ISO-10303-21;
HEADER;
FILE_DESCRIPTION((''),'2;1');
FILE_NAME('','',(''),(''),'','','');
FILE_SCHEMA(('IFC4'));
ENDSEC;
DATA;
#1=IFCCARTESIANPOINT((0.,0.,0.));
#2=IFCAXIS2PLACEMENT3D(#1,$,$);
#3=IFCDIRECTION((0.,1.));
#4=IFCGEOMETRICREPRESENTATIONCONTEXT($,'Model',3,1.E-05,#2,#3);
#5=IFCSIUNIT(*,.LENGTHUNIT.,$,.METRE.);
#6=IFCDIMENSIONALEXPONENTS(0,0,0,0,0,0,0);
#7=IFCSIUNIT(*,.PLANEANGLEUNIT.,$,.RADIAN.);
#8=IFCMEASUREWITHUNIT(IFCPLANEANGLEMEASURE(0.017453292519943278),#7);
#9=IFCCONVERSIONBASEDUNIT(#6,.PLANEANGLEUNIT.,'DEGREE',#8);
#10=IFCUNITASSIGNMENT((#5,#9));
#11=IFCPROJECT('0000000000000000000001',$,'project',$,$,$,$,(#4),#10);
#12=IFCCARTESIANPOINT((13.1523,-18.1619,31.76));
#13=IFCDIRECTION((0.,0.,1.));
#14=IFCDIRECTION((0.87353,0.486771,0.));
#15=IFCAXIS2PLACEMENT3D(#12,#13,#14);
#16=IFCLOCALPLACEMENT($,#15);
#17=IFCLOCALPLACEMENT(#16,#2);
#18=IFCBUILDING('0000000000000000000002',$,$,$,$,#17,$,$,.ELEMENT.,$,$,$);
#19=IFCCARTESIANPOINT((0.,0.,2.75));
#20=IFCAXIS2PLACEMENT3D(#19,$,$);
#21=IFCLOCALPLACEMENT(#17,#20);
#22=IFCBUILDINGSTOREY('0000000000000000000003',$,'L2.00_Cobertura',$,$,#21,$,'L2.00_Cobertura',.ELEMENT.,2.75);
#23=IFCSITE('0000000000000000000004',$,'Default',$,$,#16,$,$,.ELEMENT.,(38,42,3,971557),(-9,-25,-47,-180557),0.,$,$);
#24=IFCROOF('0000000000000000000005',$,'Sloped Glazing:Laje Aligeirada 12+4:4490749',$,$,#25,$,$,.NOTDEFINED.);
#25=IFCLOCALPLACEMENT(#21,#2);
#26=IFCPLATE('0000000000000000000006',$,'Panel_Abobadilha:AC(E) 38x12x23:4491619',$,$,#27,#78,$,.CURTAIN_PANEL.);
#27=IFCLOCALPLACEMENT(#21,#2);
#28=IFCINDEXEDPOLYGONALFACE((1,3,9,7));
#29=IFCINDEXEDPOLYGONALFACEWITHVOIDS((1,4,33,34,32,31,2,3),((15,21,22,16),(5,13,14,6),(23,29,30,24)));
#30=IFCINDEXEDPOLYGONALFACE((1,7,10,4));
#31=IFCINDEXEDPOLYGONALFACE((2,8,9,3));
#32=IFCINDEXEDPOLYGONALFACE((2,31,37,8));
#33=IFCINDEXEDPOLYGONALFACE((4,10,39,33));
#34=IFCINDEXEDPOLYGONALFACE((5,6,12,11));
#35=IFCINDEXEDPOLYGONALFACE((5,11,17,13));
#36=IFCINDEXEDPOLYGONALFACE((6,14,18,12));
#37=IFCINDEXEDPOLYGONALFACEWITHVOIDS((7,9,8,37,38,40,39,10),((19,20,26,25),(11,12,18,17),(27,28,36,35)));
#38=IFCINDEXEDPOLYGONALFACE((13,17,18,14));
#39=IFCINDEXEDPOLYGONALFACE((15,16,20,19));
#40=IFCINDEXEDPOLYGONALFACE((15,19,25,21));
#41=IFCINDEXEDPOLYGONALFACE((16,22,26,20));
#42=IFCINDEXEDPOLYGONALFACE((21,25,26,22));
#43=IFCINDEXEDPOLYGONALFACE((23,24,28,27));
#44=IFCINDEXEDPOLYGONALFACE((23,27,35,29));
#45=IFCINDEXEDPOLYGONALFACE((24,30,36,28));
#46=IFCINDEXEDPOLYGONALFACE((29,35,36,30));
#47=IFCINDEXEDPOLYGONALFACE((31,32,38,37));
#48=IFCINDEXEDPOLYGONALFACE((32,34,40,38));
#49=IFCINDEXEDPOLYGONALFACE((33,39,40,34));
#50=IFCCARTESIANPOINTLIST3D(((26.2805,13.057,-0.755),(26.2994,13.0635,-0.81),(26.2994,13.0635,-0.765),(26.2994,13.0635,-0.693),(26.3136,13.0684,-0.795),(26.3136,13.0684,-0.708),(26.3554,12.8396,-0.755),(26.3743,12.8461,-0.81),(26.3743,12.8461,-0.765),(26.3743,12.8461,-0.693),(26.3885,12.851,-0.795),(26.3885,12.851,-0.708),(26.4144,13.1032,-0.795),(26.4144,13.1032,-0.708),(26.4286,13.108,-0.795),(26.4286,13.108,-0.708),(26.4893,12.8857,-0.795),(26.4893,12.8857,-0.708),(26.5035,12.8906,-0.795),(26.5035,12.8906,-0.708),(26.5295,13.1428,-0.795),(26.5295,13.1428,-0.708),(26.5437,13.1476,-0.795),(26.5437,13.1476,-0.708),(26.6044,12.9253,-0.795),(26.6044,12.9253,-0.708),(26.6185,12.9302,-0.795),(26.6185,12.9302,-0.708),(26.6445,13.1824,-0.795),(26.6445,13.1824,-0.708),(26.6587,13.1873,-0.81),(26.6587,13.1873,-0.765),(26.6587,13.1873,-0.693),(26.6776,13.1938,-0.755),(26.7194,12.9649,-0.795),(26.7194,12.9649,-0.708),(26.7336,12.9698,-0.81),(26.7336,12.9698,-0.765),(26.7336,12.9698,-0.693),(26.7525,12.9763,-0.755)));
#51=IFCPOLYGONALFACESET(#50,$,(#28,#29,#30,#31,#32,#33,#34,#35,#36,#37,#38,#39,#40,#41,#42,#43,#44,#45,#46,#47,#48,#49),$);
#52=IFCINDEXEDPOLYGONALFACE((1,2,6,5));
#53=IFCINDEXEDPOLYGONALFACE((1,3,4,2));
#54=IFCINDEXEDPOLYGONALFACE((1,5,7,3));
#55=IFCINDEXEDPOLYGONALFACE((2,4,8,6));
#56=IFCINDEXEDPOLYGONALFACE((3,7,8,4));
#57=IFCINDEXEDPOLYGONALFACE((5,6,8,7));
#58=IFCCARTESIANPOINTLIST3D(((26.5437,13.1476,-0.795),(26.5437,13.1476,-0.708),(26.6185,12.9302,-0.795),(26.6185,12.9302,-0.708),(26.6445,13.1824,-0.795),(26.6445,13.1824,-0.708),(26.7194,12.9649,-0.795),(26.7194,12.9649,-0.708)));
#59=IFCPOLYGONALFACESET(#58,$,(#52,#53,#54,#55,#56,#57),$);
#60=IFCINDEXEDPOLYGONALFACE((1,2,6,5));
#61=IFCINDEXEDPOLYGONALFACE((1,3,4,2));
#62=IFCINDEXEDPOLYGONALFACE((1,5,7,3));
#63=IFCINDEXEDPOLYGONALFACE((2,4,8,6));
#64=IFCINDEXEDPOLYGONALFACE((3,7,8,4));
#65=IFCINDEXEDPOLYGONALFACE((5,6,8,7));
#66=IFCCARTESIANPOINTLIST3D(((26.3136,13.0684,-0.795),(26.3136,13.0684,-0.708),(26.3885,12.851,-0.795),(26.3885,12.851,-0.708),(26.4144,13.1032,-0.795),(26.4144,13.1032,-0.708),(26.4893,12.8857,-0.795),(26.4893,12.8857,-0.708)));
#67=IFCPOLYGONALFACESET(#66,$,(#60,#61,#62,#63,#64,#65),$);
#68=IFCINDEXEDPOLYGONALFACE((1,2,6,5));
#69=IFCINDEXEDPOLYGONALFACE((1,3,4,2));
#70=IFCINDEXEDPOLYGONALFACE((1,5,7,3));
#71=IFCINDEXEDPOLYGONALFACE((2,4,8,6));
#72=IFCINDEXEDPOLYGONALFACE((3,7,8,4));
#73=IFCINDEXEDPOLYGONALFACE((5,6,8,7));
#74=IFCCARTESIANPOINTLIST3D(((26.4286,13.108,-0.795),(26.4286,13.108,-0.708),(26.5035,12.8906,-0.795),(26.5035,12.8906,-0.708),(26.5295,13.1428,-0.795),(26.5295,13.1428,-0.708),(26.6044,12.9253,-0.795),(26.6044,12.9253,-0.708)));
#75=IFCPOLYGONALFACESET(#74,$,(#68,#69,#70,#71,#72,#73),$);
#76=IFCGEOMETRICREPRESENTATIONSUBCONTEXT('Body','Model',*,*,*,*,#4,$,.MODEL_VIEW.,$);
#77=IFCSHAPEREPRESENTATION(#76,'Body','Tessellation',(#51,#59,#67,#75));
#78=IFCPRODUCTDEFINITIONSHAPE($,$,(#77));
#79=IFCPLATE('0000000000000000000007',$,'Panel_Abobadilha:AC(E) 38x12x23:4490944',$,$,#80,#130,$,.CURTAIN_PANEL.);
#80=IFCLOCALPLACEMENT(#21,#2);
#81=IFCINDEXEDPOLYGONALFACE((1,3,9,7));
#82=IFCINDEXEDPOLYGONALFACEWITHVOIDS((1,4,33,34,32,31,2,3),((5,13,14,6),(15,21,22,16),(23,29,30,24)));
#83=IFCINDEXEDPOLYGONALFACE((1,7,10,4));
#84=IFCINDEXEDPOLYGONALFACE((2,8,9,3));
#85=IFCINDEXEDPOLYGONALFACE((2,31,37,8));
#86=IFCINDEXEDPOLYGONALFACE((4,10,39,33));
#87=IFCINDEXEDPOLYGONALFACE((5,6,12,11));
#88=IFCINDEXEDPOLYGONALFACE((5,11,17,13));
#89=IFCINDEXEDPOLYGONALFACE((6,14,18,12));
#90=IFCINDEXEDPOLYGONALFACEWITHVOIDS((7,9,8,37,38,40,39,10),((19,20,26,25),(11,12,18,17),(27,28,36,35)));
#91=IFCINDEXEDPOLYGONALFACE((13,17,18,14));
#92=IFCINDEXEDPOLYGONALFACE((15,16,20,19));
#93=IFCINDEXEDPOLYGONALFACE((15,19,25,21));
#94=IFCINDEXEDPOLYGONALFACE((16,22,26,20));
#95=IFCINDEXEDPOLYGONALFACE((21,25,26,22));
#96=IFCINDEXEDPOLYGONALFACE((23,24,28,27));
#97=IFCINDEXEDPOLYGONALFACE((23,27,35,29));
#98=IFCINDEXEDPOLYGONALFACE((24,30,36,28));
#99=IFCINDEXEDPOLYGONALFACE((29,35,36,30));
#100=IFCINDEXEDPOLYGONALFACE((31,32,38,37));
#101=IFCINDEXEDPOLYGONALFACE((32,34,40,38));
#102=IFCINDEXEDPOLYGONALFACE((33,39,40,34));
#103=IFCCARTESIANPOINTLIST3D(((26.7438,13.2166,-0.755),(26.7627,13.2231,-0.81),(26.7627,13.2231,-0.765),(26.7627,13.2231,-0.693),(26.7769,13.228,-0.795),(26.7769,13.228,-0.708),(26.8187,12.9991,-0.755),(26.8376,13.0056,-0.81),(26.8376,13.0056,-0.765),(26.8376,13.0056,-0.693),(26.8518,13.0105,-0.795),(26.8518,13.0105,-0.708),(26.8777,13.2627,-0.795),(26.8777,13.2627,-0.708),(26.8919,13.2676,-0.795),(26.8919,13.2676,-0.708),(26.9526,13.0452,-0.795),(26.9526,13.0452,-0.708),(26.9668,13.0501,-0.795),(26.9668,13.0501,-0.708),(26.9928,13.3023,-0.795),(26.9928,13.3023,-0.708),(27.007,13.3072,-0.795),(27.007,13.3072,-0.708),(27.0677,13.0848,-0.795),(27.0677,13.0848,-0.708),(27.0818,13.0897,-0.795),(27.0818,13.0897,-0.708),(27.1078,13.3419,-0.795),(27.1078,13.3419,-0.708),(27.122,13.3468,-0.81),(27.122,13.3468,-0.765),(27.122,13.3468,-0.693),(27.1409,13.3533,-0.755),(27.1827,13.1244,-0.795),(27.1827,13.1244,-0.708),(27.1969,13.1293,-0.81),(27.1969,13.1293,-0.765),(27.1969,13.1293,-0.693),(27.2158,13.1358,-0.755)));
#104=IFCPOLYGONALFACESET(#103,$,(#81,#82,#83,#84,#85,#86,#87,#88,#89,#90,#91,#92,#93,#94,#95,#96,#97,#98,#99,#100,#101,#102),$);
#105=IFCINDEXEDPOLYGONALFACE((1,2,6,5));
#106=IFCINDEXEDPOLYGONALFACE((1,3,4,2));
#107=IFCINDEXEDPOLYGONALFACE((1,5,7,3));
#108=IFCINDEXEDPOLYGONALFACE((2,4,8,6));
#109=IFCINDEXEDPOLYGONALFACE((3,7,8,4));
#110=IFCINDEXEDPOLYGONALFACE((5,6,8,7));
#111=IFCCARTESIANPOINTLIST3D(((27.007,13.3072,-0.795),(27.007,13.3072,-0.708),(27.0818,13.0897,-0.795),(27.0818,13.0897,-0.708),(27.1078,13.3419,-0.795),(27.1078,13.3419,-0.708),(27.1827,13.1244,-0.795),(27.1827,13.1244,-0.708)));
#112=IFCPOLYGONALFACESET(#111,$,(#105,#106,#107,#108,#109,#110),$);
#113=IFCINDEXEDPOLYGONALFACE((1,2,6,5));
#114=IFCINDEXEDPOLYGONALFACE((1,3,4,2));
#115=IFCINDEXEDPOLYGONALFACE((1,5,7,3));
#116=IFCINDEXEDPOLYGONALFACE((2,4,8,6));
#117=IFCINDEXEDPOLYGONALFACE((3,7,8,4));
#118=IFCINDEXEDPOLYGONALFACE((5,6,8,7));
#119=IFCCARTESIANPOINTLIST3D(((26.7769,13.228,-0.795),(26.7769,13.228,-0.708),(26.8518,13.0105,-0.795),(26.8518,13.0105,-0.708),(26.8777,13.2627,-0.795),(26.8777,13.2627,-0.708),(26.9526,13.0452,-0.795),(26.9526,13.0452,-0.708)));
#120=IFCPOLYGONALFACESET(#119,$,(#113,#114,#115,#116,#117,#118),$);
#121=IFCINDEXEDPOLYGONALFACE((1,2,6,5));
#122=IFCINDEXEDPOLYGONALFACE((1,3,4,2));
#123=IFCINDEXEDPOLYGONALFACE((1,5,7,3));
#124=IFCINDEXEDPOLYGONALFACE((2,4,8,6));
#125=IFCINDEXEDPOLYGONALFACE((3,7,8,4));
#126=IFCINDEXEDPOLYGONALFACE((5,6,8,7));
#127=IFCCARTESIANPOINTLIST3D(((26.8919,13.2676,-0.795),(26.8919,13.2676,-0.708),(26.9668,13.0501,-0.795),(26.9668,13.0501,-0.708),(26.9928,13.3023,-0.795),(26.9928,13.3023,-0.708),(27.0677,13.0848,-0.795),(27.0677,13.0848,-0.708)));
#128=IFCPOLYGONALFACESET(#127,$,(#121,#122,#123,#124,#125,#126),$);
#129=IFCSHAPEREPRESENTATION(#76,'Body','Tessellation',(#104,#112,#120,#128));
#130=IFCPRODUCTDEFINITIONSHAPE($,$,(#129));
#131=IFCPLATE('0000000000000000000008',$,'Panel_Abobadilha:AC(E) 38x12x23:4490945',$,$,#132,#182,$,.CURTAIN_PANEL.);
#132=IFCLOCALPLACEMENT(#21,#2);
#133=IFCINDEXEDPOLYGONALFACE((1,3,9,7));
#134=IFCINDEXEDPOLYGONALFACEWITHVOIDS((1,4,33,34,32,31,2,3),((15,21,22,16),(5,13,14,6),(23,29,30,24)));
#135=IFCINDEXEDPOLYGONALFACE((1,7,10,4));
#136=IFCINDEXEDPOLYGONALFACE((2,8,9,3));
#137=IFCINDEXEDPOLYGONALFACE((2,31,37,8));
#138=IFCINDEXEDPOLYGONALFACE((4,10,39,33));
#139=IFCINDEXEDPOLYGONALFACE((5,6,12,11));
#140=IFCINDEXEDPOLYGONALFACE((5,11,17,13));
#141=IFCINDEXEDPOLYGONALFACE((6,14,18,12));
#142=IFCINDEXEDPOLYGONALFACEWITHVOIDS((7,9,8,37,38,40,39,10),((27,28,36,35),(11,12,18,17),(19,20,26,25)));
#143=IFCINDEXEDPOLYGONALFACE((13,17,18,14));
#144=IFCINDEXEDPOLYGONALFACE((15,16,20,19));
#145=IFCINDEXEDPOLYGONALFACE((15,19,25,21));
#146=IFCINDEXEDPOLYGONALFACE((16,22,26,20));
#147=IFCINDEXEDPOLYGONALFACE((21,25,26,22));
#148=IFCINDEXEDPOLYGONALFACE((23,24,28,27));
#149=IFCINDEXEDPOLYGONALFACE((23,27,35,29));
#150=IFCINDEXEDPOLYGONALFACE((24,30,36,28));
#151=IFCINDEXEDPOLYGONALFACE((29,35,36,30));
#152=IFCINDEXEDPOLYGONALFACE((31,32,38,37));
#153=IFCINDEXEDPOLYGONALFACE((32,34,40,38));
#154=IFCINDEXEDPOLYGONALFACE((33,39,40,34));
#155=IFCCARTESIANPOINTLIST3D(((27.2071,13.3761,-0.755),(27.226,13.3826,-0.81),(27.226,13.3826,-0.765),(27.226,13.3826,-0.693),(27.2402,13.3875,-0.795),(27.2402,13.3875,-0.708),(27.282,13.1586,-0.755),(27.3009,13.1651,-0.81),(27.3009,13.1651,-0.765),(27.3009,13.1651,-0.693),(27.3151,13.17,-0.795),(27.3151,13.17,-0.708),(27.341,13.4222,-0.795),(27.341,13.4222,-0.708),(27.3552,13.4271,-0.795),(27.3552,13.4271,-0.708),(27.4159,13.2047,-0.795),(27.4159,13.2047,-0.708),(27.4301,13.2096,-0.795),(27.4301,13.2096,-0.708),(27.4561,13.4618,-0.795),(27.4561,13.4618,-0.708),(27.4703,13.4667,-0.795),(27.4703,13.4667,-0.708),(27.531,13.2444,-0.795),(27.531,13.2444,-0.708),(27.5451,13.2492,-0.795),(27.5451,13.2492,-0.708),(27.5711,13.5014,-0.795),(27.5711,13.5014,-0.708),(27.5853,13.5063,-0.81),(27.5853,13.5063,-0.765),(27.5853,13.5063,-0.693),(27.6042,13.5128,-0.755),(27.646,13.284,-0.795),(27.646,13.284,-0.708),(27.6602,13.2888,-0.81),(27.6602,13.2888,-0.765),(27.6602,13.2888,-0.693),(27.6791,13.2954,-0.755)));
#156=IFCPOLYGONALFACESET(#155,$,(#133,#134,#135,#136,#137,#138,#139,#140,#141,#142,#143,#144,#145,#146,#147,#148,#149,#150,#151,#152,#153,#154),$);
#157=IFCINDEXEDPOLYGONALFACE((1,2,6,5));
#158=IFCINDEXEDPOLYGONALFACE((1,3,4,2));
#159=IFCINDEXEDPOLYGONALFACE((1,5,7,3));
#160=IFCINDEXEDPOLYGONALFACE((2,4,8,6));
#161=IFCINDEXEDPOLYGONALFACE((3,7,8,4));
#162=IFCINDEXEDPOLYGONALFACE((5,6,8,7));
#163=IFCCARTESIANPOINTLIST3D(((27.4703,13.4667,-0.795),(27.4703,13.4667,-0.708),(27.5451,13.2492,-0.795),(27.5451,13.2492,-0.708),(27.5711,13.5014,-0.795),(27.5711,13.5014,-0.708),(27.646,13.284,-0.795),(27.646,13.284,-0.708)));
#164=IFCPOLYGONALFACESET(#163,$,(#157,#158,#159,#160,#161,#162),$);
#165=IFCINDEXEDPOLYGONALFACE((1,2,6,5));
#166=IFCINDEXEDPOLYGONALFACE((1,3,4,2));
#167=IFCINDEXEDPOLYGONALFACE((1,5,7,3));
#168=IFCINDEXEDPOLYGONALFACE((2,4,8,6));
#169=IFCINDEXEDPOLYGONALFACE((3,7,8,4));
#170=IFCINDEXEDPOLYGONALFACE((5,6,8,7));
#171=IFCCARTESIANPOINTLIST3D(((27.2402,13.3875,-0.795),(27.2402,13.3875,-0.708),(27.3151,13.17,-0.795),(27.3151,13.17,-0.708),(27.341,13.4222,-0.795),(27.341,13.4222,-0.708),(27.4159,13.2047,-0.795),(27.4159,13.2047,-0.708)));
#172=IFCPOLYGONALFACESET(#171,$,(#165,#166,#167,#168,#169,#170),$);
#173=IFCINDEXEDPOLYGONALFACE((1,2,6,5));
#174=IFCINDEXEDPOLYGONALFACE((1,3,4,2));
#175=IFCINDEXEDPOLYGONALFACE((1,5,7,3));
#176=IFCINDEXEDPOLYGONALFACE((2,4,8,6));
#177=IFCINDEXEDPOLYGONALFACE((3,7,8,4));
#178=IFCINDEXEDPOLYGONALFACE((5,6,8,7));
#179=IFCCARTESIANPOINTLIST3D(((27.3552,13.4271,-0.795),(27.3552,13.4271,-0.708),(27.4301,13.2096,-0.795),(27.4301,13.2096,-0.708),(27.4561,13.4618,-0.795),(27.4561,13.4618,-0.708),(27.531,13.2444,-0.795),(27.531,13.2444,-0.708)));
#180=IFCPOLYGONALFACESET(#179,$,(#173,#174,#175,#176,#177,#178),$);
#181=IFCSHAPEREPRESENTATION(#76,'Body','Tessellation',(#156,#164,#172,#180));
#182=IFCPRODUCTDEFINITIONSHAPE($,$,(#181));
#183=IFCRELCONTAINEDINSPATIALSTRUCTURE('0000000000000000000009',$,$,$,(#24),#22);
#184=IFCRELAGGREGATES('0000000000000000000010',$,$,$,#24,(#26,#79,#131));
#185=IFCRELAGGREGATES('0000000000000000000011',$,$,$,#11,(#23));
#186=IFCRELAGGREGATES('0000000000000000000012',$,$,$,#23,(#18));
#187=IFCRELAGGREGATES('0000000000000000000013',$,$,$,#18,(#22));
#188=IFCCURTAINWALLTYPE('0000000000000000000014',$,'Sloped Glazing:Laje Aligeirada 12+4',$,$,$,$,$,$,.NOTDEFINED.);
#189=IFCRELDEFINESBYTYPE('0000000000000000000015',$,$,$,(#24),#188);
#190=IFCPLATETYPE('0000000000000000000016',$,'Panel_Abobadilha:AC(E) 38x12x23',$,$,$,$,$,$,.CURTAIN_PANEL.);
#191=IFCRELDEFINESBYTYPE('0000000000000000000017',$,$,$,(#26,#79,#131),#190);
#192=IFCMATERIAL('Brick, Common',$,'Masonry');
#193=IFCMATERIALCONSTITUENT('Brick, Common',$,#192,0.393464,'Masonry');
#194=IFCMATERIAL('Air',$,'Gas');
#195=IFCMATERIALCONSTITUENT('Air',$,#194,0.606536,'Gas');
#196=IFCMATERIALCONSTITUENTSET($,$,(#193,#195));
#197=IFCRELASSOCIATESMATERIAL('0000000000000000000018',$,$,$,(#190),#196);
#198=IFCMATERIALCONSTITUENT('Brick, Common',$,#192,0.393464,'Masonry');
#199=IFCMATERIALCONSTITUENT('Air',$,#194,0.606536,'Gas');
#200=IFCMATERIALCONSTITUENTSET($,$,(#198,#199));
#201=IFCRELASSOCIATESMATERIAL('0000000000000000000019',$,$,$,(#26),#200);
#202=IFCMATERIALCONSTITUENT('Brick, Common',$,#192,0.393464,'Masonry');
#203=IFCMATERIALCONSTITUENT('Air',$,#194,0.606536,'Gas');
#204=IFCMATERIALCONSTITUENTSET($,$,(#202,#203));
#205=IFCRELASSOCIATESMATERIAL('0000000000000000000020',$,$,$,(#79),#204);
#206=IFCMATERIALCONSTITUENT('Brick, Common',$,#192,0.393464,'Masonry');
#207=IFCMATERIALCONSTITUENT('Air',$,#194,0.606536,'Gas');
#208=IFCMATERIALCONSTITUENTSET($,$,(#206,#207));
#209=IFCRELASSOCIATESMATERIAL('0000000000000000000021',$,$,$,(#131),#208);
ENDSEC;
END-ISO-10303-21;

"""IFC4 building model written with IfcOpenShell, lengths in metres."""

from ifc_helpers import new_model, entity, si_unit, converted_unit, direction, frame, origin, place, context, subcontext, project, spatial, indexed_curve, outline, extrude, source, transform, mapped, material, constituent, constituent_set, type_object, type_shapes, element, aggregate, save


model = new_model("IFC4")

# Units and contexts
model_context = context("Model", 3, precision=1e-05, world=origin(), true_north=direction((0.0, 1.0)))
body_context = subcontext(model_context, "Body", "Model", "MODEL_VIEW")
ifc_project = project(units=[si_unit("LENGTHUNIT", "METRE"), converted_unit("PLANEANGLEUNIT", "DEGREE", entity("IfcPlaneAngleMeasure", 0.017453292519943278), si_unit("PLANEANGLEUNIT", "RADIAN"), dimensions=[0, 0, 0, 0, 0, 0, 0])], contexts=[model_context])

# Site, building, storey
site_placement = place(None, frame((13.1523, -18.1619, 31.76), z_axis=(0.0, 0.0, 1.0), x_axis=(0.87353, 0.486771, 0.0)))
site = spatial("IfcSite", under=ifc_project, at=site_placement, Name="Default", CompositionType="ELEMENT", RefLatitude=(38, 42, 3, 971557), RefLongitude=(-9, -25, -47, -180557), RefElevation=0.0)
building_placement = place(site_placement, origin())
building = spatial("IfcBuilding", under=site, at=building_placement, CompositionType="ELEMENT")
storey_placement = place(building_placement, frame((0.0, 0.0, 2.75)))
storey = spatial("IfcBuildingStorey", under=building, at=storey_placement, Name="L2.00_Cobertura", LongName="L2.00_Cobertura", CompositionType="ELEMENT", Elevation=2.75)

# Roof, plates
curtain_wall_type = type_object("IfcCurtainWallType", Name="Sloped Glazing:Laje Aligeirada 12+4", PredefinedType="NOTDEFINED")
roof_placement = place(storey_placement, frame((0.0, 0.0, -2.75)))
roof = element("IfcRoof", 1, at=roof_placement, inside=storey, type_object=curtain_wall_type, Name="Sloped Glazing:Laje Aligeirada 12+4:4490749", PredefinedType="NOTDEFINED")
ifc_material_1 = material(Name="Brick, Common", Category="Masonry")
ifc_material_2 = material(Name="Air", Category="Gas")
ifc_constituent_1 = constituent(ifc_material_1, Name="Brick, Common", Category="Masonry", fraction=0.393464)
ifc_constituent_2 = constituent(ifc_material_2, Name="Air", Category="Gas", fraction=0.606536)
ifc_constituent_set_1 = constituent_set(constituents=[ifc_constituent_1, ifc_constituent_2])
plate_type = type_object("IfcPlateType", Name="Panel_Abobadilha:AC(E) 38x12x23", PredefinedType="CURTAIN_PANEL", material=ifc_constituent_set_1)
shared_shape_1 = source(origin(), body_context, "Body", "SweptSolid", [
    extrude(outline(indexed_curve([(-0.19, -0.0543), (0.19, -0.0543), (0.19, -0.0093), (0.21, 0.0007), (0.19, 0.0628), (-0.19, 0.0628), (-0.21, 0.0007), (-0.19, -0.0093), (-0.19, -0.0543)], self_intersect=False), holes=[indexed_curve([(-0.0683, 0.0477), (-0.0683, -0.0393), (-0.175, -0.0393), (-0.175, 0.0477), (-0.0683, 0.0477)], self_intersect=False), indexed_curve([(0.0533, 0.0477), (0.0533, -0.0393), (-0.0533, -0.0393), (-0.0533, 0.0477), (0.0533, 0.0477)], self_intersect=False), indexed_curve([(0.175, 0.0477), (0.175, -0.0393), (0.0683, -0.0393), (0.0683, 0.0477), (0.175, 0.0477)], self_intersect=False)]), frame((0.0, 0.0543, 0.0)), (0.0, 0.0, 1.0), 0.23),
    extrude(outline(indexed_curve([(-0.0533, -0.0435), (0.0533, -0.0435), (0.0533, 0.0435), (-0.0533, 0.0435), (-0.0533, -0.0435)], self_intersect=False)), frame((0.1217, 0.0585, 0.0), z_axis=(0.0, 0.0, 1.0), x_axis=(-1.0, 0.0, 0.0)), (0.0, 0.0, 1.0), 0.23),
    extrude(outline(indexed_curve([(-0.0533, -0.0435), (0.0533, -0.0435), (0.0533, 0.0435), (-0.0533, 0.0435), (-0.0533, -0.0435)], self_intersect=False)), frame((-0.1217, 0.0585, 0.0), z_axis=(0.0, 0.0, 1.0), x_axis=(-1.0, 0.0, 0.0)), (0.0, 0.0, 1.0), 0.23),
    extrude(outline(indexed_curve([(-0.0533, -0.0435), (0.0533, -0.0435), (0.0533, 0.0435), (-0.0533, 0.0435), (-0.0533, -0.0435)], self_intersect=False)), frame((0.0, 0.0585, 0.0), z_axis=(0.0, 0.0, 1.0), x_axis=(-1.0, 0.0, 0.0)), (0.0, 0.0, 1.0), 0.23),
])
type_shapes(plate_type, [shared_shape_1])
ifc_constituent_3 = constituent(ifc_material_1, Name="Brick, Common", Category="Masonry", fraction=0.393464)
ifc_constituent_4 = constituent(ifc_material_2, Name="Air", Category="Gas", fraction=0.606536)
ifc_constituent_set_2 = constituent_set(constituents=[ifc_constituent_3, ifc_constituent_4])
plate_1_placement = place(roof_placement, frame((26.479, 13.1254, 1.94), z_axis=(0.325568, -0.945519, 0.0), x_axis=(0.945519, 0.325568, 0.0)))
plate_1 = element("IfcPlate", 2, at=plate_1_placement, type_object=plate_type, material=ifc_constituent_set_2, Name="Panel_Abobadilha:AC(E) 38x12x23:4491619", PredefinedType="CURTAIN_PANEL", context=body_context, shape_type="MappedRepresentation", body=[
    mapped(shared_shape_1, transform((0.0, 0.0, 0.0), scale=1.0)),
])
ifc_constituent_5 = constituent(ifc_material_1, Name="Brick, Common", Category="Masonry", fraction=0.393464)
ifc_constituent_6 = constituent(ifc_material_2, Name="Air", Category="Gas", fraction=0.606536)
ifc_constituent_set_3 = constituent_set(constituents=[ifc_constituent_5, ifc_constituent_6])
plate_2_placement = place(roof_placement, frame((26.9423, 13.2849, 1.94), z_axis=(0.325568, -0.945519, 0.0), x_axis=(0.945519, 0.325568, 0.0)))
plate_2 = element("IfcPlate", 3, at=plate_2_placement, type_object=plate_type, material=ifc_constituent_set_3, Name="Panel_Abobadilha:AC(E) 38x12x23:4490944", PredefinedType="CURTAIN_PANEL", context=body_context, shape_type="MappedRepresentation", body=[
    mapped(shared_shape_1, transform((0.0, 0.0, 0.0), scale=1.0)),
])
ifc_constituent_7 = constituent(ifc_material_1, Name="Brick, Common", Category="Masonry", fraction=0.393464)
ifc_constituent_8 = constituent(ifc_material_2, Name="Air", Category="Gas", fraction=0.606536)
ifc_constituent_set_4 = constituent_set(constituents=[ifc_constituent_7, ifc_constituent_8])
plate_3_placement = place(roof_placement, frame((27.4057, 13.4445, 1.94), z_axis=(0.325568, -0.945519, 0.0), x_axis=(0.945519, 0.325568, 0.0)))
plate_3 = element("IfcPlate", 4, at=plate_3_placement, type_object=plate_type, material=ifc_constituent_set_4, Name="Panel_Abobadilha:AC(E) 38x12x23:4490945", PredefinedType="CURTAIN_PANEL", context=body_context, shape_type="MappedRepresentation", body=[
    mapped(shared_shape_1, transform((0.0, 0.0, 0.0), scale=1.0)),
])
aggregate(roof, [plate_1, plate_2, plate_3])

save(model, "model.ifc")
